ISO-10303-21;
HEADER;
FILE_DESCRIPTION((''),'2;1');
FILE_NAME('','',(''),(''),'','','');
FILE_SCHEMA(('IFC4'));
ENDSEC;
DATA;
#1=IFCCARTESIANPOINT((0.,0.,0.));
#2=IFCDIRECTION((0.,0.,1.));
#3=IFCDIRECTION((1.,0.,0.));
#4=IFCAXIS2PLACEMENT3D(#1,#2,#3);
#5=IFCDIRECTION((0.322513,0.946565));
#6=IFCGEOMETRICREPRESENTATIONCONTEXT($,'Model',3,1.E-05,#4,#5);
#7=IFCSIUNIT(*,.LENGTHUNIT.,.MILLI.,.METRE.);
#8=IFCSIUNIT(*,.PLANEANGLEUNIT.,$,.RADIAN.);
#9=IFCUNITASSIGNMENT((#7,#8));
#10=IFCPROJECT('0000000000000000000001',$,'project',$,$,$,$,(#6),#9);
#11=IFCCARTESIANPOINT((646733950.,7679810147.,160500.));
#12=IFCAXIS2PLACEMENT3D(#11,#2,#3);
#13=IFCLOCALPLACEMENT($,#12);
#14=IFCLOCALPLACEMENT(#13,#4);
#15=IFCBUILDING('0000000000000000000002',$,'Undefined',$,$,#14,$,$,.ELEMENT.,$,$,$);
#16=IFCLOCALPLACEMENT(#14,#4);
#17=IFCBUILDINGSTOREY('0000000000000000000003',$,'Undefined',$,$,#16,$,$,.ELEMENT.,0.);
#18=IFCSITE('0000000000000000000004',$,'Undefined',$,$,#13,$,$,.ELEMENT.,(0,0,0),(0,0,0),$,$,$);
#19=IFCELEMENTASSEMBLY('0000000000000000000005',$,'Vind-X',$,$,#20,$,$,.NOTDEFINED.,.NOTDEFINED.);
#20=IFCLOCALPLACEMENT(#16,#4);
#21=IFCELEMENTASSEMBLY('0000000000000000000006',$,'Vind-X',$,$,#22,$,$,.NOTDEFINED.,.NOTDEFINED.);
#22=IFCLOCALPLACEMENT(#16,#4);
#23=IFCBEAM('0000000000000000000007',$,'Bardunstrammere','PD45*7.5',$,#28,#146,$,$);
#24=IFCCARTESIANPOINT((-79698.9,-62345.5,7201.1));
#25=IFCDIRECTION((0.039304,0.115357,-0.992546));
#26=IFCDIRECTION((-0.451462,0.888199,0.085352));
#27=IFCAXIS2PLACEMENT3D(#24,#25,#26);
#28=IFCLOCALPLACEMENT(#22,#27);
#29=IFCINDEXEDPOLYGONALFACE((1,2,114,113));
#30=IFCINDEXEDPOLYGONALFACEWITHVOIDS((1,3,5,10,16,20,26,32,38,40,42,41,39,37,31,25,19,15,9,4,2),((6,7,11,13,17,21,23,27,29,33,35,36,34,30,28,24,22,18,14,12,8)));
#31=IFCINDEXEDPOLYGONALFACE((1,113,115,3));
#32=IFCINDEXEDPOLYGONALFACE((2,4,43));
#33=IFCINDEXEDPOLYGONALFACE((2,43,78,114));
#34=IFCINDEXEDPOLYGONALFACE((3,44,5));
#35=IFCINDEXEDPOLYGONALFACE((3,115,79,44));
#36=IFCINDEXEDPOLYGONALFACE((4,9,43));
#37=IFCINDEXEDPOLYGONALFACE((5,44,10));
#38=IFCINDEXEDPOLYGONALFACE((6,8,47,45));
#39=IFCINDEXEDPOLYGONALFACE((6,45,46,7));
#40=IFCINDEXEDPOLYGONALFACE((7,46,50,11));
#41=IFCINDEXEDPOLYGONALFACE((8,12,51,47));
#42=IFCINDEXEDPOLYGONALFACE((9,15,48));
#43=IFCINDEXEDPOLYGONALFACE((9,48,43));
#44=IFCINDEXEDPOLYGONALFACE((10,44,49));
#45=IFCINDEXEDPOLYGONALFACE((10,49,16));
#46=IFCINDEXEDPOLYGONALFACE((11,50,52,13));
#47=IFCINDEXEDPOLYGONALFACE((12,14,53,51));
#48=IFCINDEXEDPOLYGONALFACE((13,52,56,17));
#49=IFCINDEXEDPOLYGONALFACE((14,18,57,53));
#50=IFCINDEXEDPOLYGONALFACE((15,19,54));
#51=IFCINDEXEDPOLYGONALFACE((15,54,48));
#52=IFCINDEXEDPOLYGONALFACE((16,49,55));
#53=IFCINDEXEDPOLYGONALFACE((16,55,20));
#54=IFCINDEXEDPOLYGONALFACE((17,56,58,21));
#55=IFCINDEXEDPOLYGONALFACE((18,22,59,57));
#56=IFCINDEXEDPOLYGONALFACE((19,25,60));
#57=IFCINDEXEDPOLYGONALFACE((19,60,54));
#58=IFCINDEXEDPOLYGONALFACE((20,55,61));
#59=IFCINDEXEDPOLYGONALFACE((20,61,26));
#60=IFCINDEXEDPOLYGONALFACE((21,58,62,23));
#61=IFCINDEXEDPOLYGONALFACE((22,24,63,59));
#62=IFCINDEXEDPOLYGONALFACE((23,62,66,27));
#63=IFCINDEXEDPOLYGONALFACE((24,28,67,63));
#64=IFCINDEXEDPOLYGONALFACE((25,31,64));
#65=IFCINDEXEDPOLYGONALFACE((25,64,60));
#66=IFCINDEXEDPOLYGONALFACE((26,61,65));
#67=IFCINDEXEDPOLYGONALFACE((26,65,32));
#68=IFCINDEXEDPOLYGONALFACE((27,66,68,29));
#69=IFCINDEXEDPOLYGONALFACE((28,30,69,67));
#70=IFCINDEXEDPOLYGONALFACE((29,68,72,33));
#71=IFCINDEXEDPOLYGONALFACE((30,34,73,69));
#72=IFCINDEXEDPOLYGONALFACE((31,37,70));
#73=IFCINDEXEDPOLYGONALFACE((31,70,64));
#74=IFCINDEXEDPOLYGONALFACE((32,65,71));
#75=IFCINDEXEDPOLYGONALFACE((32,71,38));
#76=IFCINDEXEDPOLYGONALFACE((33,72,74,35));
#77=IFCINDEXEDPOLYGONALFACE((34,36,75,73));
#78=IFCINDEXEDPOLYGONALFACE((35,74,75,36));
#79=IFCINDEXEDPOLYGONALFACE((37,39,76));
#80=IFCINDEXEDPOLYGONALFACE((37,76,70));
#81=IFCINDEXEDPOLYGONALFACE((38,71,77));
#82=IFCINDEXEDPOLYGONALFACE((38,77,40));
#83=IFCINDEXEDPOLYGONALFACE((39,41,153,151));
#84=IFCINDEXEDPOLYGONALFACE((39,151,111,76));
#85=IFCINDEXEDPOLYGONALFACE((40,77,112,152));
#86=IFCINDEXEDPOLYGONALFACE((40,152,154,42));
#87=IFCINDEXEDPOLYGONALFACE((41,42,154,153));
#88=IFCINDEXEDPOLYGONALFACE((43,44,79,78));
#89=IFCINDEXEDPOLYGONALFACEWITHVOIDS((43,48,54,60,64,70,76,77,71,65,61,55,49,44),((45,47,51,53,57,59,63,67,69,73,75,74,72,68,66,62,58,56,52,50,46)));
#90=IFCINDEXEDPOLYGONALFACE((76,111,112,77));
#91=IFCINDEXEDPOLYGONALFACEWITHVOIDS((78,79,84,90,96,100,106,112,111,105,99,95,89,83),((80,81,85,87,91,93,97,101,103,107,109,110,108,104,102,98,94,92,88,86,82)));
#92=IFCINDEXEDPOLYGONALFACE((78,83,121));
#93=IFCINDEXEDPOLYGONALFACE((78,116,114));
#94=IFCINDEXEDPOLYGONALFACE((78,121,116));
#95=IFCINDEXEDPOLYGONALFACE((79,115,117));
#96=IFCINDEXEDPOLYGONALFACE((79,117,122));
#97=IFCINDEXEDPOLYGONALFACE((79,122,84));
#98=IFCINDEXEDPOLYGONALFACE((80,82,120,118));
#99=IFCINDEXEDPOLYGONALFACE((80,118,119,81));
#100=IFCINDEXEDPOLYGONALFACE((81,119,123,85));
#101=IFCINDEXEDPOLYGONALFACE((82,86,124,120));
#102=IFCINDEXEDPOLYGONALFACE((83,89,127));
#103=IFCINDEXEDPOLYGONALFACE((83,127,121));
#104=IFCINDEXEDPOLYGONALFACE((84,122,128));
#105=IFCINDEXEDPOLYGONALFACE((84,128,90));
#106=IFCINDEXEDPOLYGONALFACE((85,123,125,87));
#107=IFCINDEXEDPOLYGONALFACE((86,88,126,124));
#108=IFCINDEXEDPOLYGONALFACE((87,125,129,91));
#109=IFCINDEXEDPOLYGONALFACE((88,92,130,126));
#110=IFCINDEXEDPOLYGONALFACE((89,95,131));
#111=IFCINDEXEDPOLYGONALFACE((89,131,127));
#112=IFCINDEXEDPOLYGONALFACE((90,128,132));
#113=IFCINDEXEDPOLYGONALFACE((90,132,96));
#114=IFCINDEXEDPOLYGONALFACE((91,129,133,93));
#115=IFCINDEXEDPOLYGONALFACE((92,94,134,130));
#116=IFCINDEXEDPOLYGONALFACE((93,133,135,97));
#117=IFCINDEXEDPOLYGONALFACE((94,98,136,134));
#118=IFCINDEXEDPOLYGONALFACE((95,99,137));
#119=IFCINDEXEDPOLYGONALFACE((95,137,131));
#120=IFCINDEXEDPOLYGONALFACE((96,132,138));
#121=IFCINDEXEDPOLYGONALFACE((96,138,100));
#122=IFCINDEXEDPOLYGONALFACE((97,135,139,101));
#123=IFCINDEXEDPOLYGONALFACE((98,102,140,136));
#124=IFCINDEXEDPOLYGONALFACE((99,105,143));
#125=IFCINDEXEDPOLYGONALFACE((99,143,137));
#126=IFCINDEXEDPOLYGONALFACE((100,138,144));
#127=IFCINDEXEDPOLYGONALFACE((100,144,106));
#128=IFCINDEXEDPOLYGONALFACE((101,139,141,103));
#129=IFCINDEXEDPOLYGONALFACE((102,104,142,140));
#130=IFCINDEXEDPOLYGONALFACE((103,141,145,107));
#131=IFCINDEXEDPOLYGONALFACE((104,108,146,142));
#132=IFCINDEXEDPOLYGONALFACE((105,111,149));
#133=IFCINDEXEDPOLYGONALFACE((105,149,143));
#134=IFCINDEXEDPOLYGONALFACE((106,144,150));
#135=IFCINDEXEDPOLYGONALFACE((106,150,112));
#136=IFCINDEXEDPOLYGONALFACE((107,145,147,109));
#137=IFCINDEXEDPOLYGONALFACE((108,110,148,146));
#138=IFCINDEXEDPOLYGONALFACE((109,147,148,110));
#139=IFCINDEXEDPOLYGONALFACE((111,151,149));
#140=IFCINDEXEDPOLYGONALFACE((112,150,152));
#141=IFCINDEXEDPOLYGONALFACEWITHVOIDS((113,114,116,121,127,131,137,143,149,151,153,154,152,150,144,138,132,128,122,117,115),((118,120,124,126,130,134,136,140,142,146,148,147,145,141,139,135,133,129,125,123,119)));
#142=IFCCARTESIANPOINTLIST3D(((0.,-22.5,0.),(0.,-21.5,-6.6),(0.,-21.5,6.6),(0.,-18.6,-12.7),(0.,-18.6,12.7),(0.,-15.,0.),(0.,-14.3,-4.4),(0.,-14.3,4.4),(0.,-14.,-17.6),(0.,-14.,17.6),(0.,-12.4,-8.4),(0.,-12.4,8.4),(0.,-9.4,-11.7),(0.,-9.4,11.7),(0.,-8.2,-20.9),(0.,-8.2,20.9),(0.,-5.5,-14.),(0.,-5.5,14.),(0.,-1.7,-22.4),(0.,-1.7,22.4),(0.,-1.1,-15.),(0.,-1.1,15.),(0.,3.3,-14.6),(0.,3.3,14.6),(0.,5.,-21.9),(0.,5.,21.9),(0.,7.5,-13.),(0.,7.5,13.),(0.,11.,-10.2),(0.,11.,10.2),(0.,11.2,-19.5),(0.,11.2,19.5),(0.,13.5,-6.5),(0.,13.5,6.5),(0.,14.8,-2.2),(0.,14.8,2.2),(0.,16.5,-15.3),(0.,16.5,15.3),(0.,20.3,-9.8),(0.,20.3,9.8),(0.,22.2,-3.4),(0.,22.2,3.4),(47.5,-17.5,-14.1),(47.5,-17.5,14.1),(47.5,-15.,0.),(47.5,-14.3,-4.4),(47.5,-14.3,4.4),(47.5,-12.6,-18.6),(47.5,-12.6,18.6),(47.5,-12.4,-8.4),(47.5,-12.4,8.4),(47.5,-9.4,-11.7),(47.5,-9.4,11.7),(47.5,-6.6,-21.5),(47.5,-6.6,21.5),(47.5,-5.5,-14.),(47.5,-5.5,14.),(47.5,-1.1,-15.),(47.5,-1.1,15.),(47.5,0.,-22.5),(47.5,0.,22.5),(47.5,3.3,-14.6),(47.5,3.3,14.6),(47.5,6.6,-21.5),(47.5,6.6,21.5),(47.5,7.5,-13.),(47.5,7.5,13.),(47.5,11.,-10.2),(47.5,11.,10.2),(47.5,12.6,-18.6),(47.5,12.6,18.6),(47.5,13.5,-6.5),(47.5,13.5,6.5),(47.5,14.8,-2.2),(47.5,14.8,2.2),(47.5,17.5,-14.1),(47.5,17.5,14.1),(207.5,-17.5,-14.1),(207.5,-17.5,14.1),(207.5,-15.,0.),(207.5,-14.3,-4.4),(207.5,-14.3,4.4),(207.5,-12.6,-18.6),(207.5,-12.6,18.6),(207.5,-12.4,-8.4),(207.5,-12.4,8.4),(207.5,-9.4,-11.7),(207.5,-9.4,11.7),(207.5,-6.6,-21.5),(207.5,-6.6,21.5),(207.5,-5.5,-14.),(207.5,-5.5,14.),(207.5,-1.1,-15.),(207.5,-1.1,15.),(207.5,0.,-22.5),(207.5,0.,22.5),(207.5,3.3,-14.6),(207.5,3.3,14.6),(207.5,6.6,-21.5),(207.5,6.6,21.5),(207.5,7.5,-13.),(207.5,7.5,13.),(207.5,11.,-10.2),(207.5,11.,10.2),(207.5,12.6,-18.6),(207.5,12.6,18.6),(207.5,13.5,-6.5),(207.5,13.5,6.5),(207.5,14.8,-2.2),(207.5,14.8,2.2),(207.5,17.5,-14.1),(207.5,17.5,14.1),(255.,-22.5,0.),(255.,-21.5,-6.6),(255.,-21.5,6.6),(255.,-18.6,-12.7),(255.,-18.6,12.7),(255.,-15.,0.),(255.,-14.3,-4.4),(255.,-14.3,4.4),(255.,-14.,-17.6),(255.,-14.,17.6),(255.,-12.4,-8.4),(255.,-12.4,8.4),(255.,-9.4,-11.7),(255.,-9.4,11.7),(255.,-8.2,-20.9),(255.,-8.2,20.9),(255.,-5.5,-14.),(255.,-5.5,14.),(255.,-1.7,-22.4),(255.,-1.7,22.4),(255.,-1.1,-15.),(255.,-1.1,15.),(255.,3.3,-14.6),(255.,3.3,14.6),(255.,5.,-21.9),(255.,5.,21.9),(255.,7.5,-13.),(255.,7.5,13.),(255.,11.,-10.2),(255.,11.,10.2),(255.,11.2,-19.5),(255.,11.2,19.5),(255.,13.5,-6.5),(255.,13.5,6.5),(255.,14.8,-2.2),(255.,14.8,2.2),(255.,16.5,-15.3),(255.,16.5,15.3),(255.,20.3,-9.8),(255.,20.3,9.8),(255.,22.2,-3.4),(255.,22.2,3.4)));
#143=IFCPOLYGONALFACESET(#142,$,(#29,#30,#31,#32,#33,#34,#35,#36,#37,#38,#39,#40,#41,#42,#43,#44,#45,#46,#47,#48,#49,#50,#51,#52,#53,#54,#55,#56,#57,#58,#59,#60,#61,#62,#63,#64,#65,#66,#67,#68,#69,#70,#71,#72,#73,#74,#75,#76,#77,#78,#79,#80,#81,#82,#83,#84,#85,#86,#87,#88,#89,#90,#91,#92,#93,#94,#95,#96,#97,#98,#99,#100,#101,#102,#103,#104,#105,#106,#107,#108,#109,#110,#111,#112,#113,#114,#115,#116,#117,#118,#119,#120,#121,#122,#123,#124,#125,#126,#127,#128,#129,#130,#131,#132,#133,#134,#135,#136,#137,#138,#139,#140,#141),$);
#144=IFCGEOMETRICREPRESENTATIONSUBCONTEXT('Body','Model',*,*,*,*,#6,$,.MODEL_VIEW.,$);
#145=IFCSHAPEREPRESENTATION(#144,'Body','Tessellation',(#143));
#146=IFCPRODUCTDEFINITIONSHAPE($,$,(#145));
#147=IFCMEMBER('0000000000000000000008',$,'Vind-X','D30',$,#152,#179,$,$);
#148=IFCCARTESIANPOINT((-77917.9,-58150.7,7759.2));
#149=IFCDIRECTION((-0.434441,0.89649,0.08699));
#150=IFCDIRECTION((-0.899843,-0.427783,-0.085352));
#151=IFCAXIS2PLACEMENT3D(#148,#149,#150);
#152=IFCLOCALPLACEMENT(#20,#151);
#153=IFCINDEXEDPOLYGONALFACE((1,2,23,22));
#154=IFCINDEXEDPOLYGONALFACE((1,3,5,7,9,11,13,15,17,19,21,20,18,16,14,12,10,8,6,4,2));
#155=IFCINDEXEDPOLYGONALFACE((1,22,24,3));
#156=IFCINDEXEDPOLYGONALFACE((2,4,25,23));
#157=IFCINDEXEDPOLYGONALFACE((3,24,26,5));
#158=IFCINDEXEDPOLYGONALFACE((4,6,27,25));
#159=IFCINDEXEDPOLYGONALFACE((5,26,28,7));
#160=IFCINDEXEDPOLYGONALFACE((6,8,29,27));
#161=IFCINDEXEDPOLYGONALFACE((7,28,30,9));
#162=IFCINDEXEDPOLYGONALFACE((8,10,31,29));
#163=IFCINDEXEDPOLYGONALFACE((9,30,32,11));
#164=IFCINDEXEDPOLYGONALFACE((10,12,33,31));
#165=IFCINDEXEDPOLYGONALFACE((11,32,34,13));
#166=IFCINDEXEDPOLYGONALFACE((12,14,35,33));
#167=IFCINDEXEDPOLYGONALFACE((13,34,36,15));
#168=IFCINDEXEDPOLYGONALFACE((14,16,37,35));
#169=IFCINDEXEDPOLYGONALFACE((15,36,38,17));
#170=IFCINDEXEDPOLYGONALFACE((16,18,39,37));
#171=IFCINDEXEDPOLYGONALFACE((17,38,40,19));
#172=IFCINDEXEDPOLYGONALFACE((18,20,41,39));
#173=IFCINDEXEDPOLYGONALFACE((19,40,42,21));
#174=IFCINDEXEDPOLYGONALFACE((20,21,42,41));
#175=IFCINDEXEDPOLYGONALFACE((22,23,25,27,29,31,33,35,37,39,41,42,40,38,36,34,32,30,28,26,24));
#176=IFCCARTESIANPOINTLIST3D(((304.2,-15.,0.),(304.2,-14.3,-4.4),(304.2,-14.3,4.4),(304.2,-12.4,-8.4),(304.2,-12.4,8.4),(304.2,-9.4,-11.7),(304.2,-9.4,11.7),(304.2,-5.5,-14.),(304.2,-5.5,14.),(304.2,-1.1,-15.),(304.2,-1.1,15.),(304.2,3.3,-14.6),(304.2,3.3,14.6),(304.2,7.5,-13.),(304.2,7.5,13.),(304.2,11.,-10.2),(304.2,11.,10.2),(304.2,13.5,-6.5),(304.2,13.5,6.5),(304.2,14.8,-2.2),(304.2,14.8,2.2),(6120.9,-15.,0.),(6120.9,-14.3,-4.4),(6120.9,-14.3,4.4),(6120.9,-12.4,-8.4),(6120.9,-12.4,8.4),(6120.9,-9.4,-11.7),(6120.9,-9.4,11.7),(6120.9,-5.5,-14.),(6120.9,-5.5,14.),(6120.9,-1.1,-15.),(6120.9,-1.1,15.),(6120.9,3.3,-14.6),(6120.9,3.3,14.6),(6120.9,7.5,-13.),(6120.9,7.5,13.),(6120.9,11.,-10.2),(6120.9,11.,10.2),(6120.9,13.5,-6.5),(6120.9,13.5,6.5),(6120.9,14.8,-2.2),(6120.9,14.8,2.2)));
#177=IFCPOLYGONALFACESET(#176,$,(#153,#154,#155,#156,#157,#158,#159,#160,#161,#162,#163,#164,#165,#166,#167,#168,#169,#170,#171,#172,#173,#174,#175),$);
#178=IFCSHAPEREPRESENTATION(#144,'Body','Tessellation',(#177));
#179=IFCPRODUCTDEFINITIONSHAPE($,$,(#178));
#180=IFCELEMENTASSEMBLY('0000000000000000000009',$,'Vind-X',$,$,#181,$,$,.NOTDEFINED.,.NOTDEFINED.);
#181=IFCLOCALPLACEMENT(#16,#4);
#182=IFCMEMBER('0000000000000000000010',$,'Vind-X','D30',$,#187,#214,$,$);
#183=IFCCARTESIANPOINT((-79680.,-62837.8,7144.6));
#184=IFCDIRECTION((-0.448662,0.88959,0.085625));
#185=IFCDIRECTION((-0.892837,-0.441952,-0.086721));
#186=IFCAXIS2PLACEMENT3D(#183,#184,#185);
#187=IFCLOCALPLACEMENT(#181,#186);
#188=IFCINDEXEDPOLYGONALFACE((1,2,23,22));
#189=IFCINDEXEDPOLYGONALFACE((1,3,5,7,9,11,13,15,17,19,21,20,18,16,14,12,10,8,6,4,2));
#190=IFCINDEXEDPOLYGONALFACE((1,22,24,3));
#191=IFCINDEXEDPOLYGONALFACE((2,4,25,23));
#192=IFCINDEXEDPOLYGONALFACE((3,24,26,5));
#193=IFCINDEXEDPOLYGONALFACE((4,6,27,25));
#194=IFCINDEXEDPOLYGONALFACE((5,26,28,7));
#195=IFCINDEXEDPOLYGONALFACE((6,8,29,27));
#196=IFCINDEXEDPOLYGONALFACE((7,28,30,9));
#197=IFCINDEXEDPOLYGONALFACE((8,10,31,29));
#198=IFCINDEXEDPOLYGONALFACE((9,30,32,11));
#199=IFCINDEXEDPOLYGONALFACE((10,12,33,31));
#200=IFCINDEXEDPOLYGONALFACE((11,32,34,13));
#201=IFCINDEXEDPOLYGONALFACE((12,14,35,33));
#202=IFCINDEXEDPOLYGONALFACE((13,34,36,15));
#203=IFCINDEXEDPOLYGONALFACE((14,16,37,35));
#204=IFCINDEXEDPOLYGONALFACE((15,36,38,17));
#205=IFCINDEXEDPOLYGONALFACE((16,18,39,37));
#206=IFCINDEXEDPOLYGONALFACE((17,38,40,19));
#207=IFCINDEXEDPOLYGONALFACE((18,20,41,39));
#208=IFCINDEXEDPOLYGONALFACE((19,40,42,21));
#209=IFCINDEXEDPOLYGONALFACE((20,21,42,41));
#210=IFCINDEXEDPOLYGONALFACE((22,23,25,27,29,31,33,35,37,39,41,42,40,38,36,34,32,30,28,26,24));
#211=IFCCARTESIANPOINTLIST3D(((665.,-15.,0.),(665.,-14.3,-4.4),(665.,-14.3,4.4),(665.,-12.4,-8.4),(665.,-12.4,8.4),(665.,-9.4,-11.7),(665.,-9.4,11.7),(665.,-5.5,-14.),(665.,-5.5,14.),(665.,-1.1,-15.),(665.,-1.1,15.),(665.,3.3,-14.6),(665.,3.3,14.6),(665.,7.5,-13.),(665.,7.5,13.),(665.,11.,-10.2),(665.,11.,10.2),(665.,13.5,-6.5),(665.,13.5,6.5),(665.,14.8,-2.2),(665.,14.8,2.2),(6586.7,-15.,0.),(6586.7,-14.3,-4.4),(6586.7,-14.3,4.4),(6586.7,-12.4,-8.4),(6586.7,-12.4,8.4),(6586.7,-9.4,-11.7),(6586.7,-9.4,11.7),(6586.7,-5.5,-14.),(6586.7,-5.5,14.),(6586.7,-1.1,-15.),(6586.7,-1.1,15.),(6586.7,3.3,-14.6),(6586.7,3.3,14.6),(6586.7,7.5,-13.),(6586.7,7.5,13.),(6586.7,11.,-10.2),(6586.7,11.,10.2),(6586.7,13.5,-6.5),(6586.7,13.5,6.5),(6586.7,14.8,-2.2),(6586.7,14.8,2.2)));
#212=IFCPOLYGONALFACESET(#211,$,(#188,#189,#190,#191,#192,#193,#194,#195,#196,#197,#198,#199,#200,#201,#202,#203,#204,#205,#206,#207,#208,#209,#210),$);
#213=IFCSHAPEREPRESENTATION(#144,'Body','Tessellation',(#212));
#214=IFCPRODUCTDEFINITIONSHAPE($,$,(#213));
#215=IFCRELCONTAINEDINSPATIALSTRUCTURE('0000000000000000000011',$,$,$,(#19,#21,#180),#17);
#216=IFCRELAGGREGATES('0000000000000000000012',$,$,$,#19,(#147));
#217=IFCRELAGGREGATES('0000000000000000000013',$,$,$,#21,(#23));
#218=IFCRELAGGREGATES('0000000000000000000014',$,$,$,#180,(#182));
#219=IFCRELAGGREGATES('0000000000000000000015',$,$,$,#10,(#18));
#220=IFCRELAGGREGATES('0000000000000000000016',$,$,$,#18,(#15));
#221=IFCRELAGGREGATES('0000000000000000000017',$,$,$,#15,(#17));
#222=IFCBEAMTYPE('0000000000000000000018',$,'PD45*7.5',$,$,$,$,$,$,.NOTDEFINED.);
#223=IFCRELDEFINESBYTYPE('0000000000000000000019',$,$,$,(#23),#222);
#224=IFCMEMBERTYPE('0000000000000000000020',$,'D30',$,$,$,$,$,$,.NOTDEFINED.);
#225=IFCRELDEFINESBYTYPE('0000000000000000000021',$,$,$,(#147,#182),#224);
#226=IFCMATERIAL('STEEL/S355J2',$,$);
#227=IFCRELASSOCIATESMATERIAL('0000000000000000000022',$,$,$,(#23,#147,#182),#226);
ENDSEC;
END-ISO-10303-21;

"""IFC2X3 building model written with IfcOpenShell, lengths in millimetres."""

from ifc_helpers import new_model, si_unit, direction, frame, origin_with_axes, origin_2d_with_axis, place, context, subcontext, project, spatial, rectangle, circle, hollow_circle, extrude, boolean, clip, halfspace, material, type_object, element, aggregate, save


model = new_model("IFC2X3")

# Units and contexts
model_context = context("Model", 3, precision=1e-05, world=origin_with_axes(), true_north=direction((0.322513, 0.946565)))
body_context = subcontext(model_context, "Body", "Model", "MODEL_VIEW")
ifc_project = project(units=[si_unit("LENGTHUNIT", "METRE", prefix="MILLI"), si_unit("PLANEANGLEUNIT", "RADIAN")], contexts=[model_context])

# Site, building, storey
site_placement = place(None, frame((646733950.0, 7679810147.0, 160500.0), z_axis=(0.0, 0.0, 1.0), x_axis=(1.0, 0.0, 0.0)))
site = spatial("IfcSite", under=ifc_project, at=site_placement, Name="Undefined", CompositionType="ELEMENT", RefLatitude=(0, 0, 0), RefLongitude=(0, 0, 0))
building_placement = place(site_placement, origin_with_axes())
building = spatial("IfcBuilding", under=site, at=building_placement, Name="Undefined", CompositionType="ELEMENT")
storey_placement = place(building_placement, origin_with_axes())
storey = spatial("IfcBuildingStorey", under=building, at=storey_placement, Name="Undefined", CompositionType="ELEMENT", Elevation=0.0)

# Element assemblies, beam
assembly_1_placement = place(storey_placement, origin_with_axes())
assembly_1 = element("IfcElementAssembly", 1, at=assembly_1_placement, inside=storey, Name="Vind-X", AssemblyPlace="NOTDEFINED", PredefinedType="NOTDEFINED")
ifc_material_1 = material(Name="STEEL/S355J2")
beam_type_1 = type_object("IfcBeamType", Name="PD45*7.5", PredefinedType="NOTDEFINED")
assembly_2_placement = place(storey_placement, origin_with_axes())
assembly_2 = element("IfcElementAssembly", 2, at=assembly_2_placement, inside=storey, Name="Vind-X", AssemblyPlace="NOTDEFINED", PredefinedType="NOTDEFINED")
beam_1_placement = place(assembly_2_placement, frame((-79698.9, -62345.5, 7201.1), z_axis=(0.039304, 0.115357, -0.992546), x_axis=(-0.451462, 0.888199, 0.085352)))
beam_1 = element("IfcBeam", 3, at=beam_1_placement, type_object=beam_type_1, material=ifc_material_1, Name="Bardunstrammere", Description="PD45*7.5", context=body_context, shape_type="CSG", body=[
    boolean("DIFFERENCE", extrude(hollow_circle(Radius=22.5, WallThickness=7.5, at=origin_2d_with_axis()), frame((255.0, 0.0, 0.0), z_axis=(-1.0, 0.0, 0.0), x_axis=(0.0, -1.0, 0.0)), (0.0, 0.0, 1.0), 255.0), extrude(rectangle(XDim=35.0, YDim=90.0, at=origin_2d_with_axis()), frame((207.5, 0.0, 0.0), z_axis=(-1.0, 0.0, 0.0), x_axis=(0.0, -1.0, 0.0)), (0.0, 0.0, 1.0), 160.0)),
])

# Member
member_type = type_object("IfcMemberType", Name="D30", PredefinedType="NOTDEFINED")
member_1_placement = place(assembly_1_placement, frame((-77917.9, -58150.7, 7759.2), z_axis=(-0.434441, 0.89649, 0.08699), x_axis=(-0.899843, -0.427783, -0.085352)))
member_1 = element("IfcMember", 4, at=member_1_placement, type_object=member_type, material=ifc_material_1, Name="Vind-X", Description="D30", context=body_context, shape_type="Clipping", body=[
    clip(clip(extrude(circle(Radius=15.0, at=origin_2d_with_axis()), frame((6785.9, 0.0, 0.0), z_axis=(-1.0, 0.0, 0.0), x_axis=(0.0, -1.0, 0.0)), (0.0, 0.0, 1.0), 6785.9), halfspace(frame((6120.9, -6.0, 10.2), z_axis=(1.0, 0.0, 0.0), x_axis=(0.0, 1.0, 0.0)), False)), halfspace(frame((304.2, -22.5, 0.0), z_axis=(1.0, 0.0, 0.0), x_axis=(0.0, 0.0, 1.0)), True)),
])

# Element assembly, member
assembly_3_placement = place(storey_placement, origin_with_axes())
assembly_3 = element("IfcElementAssembly", 5, at=assembly_3_placement, inside=storey, Name="Vind-X", AssemblyPlace="NOTDEFINED", PredefinedType="NOTDEFINED")
member_2_placement = place(assembly_3_placement, frame((-79680.0, -62837.8, 7144.6), z_axis=(-0.448662, 0.88959, 0.085625), x_axis=(-0.892837, -0.441952, -0.086721)))
member_2 = element("IfcMember", 6, at=member_2_placement, type_object=member_type, material=ifc_material_1, Name="Vind-X", Description="D30", context=body_context, shape_type="Clipping", body=[
    clip(clip(extrude(circle(Radius=15.0, at=origin_2d_with_axis()), frame((6671.7, 0.0, 0.0), z_axis=(-1.0, 0.0, 0.0), x_axis=(0.0, -1.0, 0.0)), (0.0, 0.0, 1.0), 6671.7), halfspace(frame((6586.7, 6.0, 16.0), z_axis=(-1.0, 0.0, 0.0), x_axis=(0.0, -1.0, 0.0)), True)), halfspace(frame((665.0, 6.0, 10.2), z_axis=(-1.0, 0.0, 0.0), x_axis=(0.0, -1.0, 0.0)), False)),
])

aggregate(assembly_1, [member_1])
aggregate(assembly_2, [beam_1])
aggregate(assembly_3, [member_2])

save(model, "model.ifc")
